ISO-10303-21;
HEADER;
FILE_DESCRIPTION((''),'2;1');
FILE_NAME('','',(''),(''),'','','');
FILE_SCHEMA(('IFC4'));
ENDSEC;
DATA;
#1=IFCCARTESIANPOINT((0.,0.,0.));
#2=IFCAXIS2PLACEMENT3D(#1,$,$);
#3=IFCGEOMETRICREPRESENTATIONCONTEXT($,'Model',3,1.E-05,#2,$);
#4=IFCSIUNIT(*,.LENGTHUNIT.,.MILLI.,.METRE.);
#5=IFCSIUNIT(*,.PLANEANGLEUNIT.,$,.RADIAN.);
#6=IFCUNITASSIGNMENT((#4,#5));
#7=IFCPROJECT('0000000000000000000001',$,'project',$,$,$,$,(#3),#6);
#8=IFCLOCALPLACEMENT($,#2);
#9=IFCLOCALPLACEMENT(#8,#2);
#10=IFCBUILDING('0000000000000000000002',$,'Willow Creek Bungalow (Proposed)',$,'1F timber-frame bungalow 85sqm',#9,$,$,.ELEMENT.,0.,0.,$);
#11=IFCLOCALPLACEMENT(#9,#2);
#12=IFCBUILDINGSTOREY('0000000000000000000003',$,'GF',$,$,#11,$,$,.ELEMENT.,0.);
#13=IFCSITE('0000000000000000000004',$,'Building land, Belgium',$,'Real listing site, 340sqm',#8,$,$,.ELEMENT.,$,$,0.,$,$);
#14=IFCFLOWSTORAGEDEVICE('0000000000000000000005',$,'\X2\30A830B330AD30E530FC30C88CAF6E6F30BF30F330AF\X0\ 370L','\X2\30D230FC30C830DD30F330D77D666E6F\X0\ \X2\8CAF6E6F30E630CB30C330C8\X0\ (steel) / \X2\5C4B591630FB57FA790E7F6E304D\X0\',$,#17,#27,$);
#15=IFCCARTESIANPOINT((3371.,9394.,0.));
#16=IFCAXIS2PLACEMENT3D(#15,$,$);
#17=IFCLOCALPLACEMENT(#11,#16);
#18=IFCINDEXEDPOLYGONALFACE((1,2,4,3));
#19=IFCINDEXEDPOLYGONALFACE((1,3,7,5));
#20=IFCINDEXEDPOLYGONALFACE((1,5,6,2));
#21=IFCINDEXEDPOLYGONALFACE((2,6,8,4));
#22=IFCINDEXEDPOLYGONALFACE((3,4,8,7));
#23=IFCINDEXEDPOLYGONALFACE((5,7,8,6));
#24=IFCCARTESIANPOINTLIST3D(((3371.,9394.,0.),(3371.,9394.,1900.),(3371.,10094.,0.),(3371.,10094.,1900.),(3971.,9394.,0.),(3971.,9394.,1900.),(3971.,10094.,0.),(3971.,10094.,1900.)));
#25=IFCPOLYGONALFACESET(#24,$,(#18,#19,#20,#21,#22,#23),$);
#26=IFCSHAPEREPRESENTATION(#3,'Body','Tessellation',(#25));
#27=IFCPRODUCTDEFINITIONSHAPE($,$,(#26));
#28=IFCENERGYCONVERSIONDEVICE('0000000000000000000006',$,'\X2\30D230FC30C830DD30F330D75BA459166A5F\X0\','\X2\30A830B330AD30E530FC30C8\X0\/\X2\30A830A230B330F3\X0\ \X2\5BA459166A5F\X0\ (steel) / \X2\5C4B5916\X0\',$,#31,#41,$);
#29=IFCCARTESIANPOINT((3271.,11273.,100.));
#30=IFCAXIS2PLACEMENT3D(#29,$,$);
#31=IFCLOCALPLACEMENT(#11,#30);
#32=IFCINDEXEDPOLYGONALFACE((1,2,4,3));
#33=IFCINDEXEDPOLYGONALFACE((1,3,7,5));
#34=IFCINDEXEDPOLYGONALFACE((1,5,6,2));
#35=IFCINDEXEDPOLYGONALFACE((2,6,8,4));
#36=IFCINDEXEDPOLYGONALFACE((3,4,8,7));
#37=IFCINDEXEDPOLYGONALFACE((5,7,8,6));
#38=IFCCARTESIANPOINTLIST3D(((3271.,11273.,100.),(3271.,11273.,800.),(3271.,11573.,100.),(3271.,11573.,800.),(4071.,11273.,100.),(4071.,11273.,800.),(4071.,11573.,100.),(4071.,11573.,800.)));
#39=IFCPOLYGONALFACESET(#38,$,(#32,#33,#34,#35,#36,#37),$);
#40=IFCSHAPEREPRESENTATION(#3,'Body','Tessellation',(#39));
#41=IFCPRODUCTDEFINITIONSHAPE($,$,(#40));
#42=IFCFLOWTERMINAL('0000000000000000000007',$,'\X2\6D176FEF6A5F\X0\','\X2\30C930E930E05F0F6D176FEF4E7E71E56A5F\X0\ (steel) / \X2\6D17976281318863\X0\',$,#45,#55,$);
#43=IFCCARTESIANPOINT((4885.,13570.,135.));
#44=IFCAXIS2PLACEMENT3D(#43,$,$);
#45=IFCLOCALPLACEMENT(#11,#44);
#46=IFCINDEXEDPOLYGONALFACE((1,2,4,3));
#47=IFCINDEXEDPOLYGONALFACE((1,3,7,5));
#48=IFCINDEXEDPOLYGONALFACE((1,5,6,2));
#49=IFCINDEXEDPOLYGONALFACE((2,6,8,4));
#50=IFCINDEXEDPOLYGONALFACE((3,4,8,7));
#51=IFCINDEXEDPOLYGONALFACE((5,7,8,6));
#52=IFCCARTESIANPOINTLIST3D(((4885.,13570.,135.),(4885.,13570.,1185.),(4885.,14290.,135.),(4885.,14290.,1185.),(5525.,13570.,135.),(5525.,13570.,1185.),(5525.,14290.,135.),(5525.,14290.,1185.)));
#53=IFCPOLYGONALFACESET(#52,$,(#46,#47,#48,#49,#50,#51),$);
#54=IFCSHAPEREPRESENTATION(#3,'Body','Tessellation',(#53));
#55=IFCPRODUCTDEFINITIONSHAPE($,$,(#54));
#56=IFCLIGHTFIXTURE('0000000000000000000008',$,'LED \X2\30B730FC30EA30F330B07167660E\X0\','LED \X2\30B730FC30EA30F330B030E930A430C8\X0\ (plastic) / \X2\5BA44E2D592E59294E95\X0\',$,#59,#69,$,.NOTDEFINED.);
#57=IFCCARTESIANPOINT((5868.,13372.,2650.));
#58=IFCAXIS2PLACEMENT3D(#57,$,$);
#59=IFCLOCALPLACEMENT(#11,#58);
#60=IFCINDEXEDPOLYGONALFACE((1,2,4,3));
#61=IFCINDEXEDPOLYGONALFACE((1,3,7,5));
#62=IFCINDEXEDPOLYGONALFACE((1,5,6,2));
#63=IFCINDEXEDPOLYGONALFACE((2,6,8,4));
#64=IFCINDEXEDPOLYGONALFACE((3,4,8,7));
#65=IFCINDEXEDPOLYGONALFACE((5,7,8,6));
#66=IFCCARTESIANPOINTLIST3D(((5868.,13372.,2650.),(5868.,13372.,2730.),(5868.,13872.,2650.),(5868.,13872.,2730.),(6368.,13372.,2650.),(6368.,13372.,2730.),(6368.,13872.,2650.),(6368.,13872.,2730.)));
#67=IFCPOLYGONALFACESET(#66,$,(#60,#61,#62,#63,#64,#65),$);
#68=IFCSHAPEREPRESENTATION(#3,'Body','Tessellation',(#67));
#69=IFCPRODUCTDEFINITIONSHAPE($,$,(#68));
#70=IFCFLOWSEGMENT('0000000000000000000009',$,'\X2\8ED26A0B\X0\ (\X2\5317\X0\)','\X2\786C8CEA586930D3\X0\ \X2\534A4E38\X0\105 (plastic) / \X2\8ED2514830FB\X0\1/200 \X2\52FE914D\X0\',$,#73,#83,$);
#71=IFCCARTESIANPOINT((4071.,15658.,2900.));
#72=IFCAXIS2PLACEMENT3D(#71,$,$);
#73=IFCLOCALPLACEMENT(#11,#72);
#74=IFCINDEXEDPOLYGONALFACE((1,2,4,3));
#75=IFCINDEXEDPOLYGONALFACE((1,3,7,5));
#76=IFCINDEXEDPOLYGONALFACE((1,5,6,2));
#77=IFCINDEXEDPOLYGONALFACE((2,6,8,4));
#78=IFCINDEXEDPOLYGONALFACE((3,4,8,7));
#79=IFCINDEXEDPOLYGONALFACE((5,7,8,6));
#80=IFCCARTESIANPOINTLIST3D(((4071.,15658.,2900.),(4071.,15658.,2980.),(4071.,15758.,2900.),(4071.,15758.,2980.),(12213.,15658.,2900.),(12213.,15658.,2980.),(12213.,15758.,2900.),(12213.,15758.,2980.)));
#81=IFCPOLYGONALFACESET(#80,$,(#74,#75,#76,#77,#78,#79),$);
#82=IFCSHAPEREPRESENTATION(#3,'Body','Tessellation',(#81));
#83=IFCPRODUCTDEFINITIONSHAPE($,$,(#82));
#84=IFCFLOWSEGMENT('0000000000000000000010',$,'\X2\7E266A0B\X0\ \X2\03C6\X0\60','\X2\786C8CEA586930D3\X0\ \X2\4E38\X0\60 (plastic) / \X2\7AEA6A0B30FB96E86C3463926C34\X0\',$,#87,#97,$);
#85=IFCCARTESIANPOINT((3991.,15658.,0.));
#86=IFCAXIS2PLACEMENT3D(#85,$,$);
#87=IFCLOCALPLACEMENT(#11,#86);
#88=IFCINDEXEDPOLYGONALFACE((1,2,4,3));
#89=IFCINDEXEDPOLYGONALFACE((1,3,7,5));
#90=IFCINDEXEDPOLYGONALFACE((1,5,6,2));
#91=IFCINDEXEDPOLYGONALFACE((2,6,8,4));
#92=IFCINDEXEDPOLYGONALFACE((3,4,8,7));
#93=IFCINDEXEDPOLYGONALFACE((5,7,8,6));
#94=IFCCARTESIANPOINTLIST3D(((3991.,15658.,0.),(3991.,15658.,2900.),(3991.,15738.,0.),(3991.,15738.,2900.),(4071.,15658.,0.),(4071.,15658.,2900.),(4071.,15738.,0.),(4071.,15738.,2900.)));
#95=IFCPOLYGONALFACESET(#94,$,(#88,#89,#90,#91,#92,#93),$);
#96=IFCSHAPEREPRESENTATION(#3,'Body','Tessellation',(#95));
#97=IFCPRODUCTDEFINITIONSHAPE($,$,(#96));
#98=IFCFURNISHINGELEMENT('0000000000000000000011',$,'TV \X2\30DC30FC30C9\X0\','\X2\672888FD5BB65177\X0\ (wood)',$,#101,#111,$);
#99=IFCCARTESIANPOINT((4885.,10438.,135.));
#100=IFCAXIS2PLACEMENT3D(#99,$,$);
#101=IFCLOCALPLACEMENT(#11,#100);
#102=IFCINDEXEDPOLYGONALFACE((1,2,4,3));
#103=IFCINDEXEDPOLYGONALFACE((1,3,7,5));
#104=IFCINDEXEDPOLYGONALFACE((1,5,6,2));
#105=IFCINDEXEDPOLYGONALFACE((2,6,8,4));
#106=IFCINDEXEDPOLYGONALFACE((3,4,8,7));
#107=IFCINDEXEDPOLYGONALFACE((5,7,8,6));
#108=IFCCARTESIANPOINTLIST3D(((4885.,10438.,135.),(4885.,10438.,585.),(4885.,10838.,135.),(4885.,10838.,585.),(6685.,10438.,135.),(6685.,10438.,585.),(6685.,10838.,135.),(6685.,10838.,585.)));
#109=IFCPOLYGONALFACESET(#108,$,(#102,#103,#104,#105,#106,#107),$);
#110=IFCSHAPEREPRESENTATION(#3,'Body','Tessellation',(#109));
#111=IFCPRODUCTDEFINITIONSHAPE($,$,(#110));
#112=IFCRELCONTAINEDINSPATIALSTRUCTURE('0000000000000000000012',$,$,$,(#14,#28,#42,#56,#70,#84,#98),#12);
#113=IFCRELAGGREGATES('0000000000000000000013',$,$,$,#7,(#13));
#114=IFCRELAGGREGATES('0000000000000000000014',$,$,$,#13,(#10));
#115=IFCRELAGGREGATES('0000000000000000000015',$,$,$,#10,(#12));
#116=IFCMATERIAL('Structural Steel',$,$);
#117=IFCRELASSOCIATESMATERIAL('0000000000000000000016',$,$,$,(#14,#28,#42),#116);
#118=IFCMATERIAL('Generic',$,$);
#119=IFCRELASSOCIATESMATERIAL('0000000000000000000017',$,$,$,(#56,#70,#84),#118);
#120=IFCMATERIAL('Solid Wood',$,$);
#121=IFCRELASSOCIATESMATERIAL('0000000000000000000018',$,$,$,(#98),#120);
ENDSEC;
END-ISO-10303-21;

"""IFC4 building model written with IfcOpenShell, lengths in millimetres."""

from ifc_helpers import new_model, si_unit, frame, frame_2d, origin, place, context, project, spatial, rectangle, extrude, material, element, save


model = new_model("IFC4")

# Units and contexts
model_context = context("Model", 3, precision=1e-05, world=origin())
ifc_project = project(units=[si_unit("LENGTHUNIT", "METRE", prefix="MILLI"), si_unit("PLANEANGLEUNIT", "RADIAN")], contexts=[model_context])

# Site, building, storey
site_placement = place(None, origin())
site = spatial("IfcSite", under=ifc_project, at=site_placement, Name="Building land, Belgium", ObjectType="Real listing site, 340sqm", CompositionType="ELEMENT", RefElevation=0.0)
building_placement = place(site_placement, origin())
building = spatial("IfcBuilding", under=site, at=building_placement, Name="Willow Creek Bungalow (Proposed)", ObjectType="1F timber-frame bungalow 85sqm", CompositionType="ELEMENT", ElevationOfRefHeight=0.0, ElevationOfTerrain=0.0)
storey_placement = place(building_placement, origin())
storey = spatial("IfcBuildingStorey", under=building, at=storey_placement, Name="GF", CompositionType="ELEMENT", Elevation=0.0)

# Shared definitions
ifc_material_1 = material(Name="Solid Wood")

# Shared definitions
ifc_material_2 = material(Name="Structural Steel")

# Shared definitions
ifc_material_3 = material(Name="Generic")

# Flow storage device
flow_storage_device_placement = place(storey_placement, frame((3371.0, 9394.0, 0.0)))
element("IfcFlowStorageDevice", 1, at=flow_storage_device_placement, inside=storey, material=ifc_material_2, Name="エコキュート貯湯タンク 370L", Description="ヒートポンプ給湯 貯湯ユニット (steel) / 屋外・基礎置き", context=model_context, shape_type="SweptSolid", body=[
    extrude(rectangle(XDim=600.0, YDim=700.0, at=frame_2d((300.0, 350.0))), frame((3371.0, 9394.0, 0.0)), (0.0, 0.0, 1.0), 1900.0),
])

# Energy conversion device
energy_conversion_device_placement = place(storey_placement, frame((3271.0, 11273.0, 100.0)))
element("IfcEnergyConversionDevice", 2, at=energy_conversion_device_placement, inside=storey, material=ifc_material_2, Name="ヒートポンプ室外機", Description="エコキュート/エアコン 室外機 (steel) / 屋外", context=model_context, shape_type="SweptSolid", body=[
    extrude(rectangle(XDim=800.0, YDim=300.0, at=frame_2d((400.0, 150.0))), frame((3271.0, 11273.0, 100.0)), (0.0, 0.0, 1.0), 700.0),
])

# Flow terminal
flow_terminal_placement = place(storey_placement, frame((4885.0, 13570.0, 135.0)))
element("IfcFlowTerminal", 3, at=flow_terminal_placement, inside=storey, material=ifc_material_2, Name="洗濯機", Description="ドラム式洗濯乾燥機 (steel) / 洗面脱衣", context=model_context, shape_type="SweptSolid", body=[
    extrude(rectangle(XDim=640.0, YDim=720.0, at=frame_2d((320.0, 360.0))), frame((4885.0, 13570.0, 135.0)), (0.0, 0.0, 1.0), 1050.0),
])

# Light fixture
light_fixture_placement = place(storey_placement, frame((5868.0, 13372.0, 2650.0)))
element("IfcLightFixture", 4, at=light_fixture_placement, inside=storey, material=ifc_material_3, Name="LED シーリング照明", Description="LED シーリングライト (plastic) / 室中央天井", PredefinedType="NOTDEFINED", context=model_context, shape_type="SweptSolid", body=[
    extrude(rectangle(XDim=500.0, YDim=500.0, at=frame_2d((250.0, 250.0))), frame((5868.0, 13372.0, 2650.0)), (0.0, 0.0, 1.0), 80.0),
])

# Flow segments
flow_segment_1_placement = place(storey_placement, frame((4071.0, 15658.0, 2900.0)))
element("IfcFlowSegment", 5, at=flow_segment_1_placement, inside=storey, material=ifc_material_3, Name="軒樋 (北)", Description="硬質塩ビ 半丸105 (plastic) / 軒先・1/200 勾配", context=model_context, shape_type="SweptSolid", body=[
    extrude(rectangle(XDim=8142.0, YDim=100.0, at=frame_2d((4071.0, 50.0))), frame((4071.0, 15658.0, 2900.0)), (0.0, 0.0, 1.0), 80.0),
])
flow_segment_2_placement = place(storey_placement, frame((3991.0, 15658.0, 0.0)))
element("IfcFlowSegment", 6, at=flow_segment_2_placement, inside=storey, material=ifc_material_3, Name="縦樋 φ60", Description="硬質塩ビ 丸60 (plastic) / 竪樋・雨水排水", context=model_context, shape_type="SweptSolid", body=[
    extrude(rectangle(XDim=80.0, YDim=80.0, at=frame_2d((40.0, 40.0))), frame((3991.0, 15658.0, 0.0)), (0.0, 0.0, 1.0), 2900.0),
])

# Furnishing element
furnishing_placement = place(storey_placement, frame((4885.0, 10438.0, 135.0)))
element("IfcFurnishingElement", 7, at=furnishing_placement, inside=storey, material=ifc_material_1, Name="TV ボード", Description="木製家具 (wood)", context=model_context, shape_type="SweptSolid", body=[
    extrude(rectangle(XDim=1800.0, YDim=400.0, at=frame_2d((900.0, 200.0))), frame((4885.0, 10438.0, 135.0)), (0.0, 0.0, 1.0), 450.0),
])

save(model, "model.ifc")
